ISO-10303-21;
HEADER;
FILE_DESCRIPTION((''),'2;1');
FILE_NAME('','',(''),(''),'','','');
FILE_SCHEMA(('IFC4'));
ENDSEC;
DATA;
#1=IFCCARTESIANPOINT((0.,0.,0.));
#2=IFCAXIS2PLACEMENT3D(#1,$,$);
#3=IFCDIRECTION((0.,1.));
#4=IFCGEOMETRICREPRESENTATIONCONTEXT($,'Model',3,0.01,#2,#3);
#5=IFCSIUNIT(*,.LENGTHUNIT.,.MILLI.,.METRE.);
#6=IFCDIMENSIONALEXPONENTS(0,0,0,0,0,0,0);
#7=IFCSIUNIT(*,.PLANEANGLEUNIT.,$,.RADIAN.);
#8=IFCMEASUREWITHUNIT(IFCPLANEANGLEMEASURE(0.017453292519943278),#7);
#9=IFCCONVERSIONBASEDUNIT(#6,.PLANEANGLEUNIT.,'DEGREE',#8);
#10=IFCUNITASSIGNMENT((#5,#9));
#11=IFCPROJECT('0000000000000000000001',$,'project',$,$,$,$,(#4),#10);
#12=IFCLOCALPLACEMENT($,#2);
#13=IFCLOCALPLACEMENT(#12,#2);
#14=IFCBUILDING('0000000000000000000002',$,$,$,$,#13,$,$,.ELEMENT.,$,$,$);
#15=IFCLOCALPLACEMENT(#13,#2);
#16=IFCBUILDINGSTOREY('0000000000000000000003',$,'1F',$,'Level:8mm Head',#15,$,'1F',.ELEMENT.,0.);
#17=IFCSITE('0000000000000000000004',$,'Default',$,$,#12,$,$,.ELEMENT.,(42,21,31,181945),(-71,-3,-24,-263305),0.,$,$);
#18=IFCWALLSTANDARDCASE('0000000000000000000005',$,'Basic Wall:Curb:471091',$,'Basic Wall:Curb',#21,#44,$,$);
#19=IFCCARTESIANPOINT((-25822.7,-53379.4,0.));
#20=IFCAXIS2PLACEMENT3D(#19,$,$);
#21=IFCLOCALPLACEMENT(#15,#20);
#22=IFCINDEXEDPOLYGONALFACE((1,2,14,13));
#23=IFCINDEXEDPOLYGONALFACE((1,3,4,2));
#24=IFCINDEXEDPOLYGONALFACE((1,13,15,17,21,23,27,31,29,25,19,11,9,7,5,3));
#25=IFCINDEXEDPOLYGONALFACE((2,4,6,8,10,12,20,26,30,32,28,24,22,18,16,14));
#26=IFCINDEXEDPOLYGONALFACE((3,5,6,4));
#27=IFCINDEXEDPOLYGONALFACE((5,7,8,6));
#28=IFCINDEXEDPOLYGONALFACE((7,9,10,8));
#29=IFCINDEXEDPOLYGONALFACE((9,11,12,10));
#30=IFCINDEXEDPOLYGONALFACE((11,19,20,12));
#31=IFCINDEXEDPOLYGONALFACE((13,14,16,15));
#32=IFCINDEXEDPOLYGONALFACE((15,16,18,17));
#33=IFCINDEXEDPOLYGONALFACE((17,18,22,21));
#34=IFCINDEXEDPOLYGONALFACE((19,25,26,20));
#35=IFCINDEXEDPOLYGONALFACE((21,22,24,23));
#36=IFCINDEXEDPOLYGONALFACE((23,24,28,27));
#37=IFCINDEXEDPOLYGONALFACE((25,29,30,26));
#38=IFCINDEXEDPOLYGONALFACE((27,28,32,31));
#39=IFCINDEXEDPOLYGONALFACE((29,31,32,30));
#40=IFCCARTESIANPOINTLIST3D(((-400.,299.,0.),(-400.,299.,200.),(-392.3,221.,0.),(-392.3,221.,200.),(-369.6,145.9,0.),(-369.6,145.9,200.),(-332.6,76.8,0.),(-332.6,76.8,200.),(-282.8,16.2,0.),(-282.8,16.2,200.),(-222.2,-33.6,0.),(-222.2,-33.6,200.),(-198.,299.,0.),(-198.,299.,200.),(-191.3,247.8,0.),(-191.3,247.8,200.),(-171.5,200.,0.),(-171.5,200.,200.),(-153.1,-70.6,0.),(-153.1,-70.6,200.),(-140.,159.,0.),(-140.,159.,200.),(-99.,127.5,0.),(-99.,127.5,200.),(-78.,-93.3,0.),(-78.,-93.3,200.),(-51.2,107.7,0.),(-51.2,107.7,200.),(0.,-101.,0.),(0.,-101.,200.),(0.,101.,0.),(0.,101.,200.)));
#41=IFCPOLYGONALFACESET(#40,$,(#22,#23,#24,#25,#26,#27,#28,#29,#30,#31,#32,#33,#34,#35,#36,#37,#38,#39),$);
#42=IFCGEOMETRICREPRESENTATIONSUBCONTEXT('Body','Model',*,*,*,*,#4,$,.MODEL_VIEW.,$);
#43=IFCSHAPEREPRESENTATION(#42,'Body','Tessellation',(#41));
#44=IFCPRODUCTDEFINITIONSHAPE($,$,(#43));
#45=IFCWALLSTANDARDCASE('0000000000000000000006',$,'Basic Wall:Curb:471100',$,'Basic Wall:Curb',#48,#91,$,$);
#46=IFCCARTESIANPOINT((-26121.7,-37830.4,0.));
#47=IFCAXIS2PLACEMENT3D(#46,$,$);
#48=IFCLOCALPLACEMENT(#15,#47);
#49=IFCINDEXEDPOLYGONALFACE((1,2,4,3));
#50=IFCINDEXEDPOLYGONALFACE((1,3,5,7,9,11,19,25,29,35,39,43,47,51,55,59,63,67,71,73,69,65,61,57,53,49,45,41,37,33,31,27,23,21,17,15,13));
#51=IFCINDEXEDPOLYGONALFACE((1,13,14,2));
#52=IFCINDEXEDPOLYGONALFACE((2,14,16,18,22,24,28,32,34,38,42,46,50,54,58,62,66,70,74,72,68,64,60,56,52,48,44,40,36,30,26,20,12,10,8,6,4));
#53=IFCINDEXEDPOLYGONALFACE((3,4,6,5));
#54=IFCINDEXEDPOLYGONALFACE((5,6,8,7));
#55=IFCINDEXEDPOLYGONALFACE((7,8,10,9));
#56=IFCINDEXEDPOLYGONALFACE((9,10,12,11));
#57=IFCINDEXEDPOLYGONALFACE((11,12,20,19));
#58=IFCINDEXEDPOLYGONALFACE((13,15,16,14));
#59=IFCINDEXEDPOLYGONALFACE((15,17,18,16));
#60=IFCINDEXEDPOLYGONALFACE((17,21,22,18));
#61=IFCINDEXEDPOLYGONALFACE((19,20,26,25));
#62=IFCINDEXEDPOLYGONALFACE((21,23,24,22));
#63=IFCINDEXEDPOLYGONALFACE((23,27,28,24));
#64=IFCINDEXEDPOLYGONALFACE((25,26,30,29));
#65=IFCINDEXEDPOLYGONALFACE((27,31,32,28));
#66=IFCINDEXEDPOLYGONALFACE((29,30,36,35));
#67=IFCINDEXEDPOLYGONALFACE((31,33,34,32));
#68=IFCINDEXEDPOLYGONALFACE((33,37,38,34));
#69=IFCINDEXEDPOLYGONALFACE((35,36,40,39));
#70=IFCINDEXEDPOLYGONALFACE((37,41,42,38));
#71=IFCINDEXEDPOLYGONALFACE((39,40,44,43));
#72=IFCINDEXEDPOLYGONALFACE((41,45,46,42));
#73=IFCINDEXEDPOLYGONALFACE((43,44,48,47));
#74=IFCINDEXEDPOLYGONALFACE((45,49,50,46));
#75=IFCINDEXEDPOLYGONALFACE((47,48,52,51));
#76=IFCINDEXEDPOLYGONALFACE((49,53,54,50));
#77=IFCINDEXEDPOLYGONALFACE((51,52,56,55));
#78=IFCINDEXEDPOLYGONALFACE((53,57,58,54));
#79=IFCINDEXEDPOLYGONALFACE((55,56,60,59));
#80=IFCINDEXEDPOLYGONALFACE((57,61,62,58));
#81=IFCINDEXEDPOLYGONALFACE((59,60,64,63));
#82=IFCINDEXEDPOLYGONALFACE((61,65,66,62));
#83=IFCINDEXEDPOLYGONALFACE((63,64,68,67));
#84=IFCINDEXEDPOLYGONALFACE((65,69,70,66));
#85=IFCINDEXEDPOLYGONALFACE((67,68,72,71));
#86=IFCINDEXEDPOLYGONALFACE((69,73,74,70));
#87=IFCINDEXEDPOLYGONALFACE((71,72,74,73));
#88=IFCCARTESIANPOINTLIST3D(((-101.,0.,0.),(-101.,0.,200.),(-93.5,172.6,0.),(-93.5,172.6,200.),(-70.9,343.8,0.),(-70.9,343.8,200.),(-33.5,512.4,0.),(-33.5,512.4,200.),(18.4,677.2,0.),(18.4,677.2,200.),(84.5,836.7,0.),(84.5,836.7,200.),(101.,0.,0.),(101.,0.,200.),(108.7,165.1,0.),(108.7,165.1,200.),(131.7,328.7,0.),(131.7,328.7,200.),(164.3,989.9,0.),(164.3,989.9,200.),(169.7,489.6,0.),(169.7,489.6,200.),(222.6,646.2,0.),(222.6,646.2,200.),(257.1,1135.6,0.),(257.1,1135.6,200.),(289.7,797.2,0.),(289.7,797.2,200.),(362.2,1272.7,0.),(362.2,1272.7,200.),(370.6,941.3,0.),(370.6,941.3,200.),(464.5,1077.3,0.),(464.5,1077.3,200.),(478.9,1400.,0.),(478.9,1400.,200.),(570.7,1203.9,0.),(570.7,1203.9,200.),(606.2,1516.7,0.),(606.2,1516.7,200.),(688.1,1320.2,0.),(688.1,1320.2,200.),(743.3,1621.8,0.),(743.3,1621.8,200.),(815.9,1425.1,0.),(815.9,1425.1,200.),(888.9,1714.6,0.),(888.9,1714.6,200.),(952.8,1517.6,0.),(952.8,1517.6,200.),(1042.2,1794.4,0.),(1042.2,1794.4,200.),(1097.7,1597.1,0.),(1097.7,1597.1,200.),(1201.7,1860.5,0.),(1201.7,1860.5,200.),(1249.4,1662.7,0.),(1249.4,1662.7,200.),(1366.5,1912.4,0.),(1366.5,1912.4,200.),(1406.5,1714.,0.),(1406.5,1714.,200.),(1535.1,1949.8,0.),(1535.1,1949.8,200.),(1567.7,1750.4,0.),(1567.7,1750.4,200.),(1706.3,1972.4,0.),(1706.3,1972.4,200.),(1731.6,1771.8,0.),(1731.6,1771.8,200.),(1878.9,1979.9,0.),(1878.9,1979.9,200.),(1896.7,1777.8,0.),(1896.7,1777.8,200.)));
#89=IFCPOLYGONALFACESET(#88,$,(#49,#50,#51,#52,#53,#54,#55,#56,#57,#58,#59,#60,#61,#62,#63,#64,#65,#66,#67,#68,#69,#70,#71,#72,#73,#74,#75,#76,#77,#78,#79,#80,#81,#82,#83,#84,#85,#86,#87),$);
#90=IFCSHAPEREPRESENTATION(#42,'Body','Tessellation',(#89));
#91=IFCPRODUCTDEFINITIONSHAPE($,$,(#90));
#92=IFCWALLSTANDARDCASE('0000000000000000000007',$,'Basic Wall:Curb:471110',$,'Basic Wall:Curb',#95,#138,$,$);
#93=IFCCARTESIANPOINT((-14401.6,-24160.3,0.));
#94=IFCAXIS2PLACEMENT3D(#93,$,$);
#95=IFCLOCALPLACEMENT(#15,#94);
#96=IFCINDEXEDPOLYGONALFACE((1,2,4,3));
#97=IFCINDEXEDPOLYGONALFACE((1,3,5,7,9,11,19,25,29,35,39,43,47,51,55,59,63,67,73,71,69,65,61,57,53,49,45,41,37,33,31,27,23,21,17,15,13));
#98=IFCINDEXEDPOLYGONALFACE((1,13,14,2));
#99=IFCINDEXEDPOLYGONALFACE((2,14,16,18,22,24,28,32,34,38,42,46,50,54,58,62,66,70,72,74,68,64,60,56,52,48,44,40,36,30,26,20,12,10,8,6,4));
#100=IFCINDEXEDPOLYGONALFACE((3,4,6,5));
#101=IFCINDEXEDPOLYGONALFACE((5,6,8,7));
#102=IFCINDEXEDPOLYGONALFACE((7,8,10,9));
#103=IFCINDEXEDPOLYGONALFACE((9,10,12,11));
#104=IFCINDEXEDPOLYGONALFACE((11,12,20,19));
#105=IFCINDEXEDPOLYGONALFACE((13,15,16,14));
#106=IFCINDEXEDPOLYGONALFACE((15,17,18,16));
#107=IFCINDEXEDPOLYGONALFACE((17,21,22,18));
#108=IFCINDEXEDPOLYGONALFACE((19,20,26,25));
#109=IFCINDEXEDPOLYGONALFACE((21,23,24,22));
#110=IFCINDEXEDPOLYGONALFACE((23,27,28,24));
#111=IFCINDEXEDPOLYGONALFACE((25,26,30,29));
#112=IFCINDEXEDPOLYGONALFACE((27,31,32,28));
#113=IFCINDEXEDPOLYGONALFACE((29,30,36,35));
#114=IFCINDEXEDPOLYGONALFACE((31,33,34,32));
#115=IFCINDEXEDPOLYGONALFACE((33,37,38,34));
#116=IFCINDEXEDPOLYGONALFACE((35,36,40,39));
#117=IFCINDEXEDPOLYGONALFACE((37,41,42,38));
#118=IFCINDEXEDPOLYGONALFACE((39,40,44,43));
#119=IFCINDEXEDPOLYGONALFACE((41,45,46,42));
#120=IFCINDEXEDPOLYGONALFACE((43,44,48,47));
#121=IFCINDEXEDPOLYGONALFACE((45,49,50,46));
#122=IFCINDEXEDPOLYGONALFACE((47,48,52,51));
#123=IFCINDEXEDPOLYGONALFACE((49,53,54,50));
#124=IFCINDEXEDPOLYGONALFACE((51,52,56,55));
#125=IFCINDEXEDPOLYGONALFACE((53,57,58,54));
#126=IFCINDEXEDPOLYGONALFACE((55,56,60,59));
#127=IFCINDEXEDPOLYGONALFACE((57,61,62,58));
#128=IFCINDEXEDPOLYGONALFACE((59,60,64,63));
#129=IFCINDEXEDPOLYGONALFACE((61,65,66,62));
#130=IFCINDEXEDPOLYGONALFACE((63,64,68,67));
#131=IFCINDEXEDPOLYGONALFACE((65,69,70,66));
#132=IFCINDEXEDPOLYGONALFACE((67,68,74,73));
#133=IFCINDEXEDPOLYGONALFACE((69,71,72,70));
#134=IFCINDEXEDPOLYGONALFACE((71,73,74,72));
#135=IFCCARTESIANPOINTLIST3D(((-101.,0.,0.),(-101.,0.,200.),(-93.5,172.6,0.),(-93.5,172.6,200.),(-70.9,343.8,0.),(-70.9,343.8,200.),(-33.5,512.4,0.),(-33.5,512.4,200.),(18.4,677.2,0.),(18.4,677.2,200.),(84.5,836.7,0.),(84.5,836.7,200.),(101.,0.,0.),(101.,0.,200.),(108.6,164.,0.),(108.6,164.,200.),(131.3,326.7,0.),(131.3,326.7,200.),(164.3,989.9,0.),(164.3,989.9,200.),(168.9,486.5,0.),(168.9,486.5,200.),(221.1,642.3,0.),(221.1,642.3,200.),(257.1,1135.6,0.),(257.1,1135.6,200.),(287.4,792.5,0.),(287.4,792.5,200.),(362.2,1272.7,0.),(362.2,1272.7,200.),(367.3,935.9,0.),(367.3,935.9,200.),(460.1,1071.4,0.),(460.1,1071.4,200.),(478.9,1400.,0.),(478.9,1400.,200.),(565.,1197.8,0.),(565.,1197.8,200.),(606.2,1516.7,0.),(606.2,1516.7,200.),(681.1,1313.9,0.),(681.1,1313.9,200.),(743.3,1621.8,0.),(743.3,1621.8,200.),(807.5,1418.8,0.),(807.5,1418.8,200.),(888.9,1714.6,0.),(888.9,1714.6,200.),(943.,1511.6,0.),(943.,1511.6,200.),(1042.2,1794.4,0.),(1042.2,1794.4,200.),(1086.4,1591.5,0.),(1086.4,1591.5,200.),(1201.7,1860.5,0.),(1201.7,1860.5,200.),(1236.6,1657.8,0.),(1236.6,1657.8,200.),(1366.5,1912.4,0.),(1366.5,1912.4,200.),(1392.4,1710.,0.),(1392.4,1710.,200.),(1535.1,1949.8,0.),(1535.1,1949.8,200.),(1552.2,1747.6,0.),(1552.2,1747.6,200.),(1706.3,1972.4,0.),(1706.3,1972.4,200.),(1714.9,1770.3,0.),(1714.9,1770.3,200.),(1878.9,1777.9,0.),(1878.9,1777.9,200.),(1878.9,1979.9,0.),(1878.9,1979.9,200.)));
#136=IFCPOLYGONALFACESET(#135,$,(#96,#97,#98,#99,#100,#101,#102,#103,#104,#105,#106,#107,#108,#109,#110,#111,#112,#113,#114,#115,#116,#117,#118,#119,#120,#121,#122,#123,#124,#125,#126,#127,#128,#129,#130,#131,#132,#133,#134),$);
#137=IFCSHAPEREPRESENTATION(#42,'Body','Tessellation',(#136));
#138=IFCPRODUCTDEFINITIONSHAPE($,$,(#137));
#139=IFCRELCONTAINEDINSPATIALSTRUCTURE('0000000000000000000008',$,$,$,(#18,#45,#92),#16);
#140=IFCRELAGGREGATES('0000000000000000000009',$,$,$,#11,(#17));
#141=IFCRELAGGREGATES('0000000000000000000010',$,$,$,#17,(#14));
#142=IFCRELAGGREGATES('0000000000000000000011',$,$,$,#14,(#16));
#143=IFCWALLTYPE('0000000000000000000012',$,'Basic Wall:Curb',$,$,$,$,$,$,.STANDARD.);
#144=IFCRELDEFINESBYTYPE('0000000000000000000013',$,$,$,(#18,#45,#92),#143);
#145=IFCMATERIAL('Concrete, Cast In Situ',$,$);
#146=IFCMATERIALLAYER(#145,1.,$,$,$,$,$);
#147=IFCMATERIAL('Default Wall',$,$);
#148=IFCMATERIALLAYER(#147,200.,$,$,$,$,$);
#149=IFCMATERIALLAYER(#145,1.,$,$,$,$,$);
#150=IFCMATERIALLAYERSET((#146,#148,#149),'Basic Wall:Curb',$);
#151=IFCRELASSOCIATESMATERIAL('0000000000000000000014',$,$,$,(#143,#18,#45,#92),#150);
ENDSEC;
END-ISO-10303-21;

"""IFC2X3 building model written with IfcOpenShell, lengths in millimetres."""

from ifc_helpers import new_model, entity, si_unit, converted_unit, direction, frame, frame_2d, origin, place, context, subcontext, project, spatial, polyline, circle_curve, parameter, trimmed, segment, composite_curve, outline, extrude, material, layer, layer_set, layer_usage, type_object, element, save


model = new_model("IFC2X3")

# Units and contexts
model_context = context("Model", 3, precision=0.01, world=origin(), true_north=direction((0.0, 1.0)))
body_context = subcontext(model_context, "Body", "Model", "MODEL_VIEW")
ifc_project = project(units=[si_unit("LENGTHUNIT", "METRE", prefix="MILLI"), converted_unit("PLANEANGLEUNIT", "DEGREE", entity("IfcPlaneAngleMeasure", 0.017453292519943278), si_unit("PLANEANGLEUNIT", "RADIAN"), dimensions=[0, 0, 0, 0, 0, 0, 0])], contexts=[model_context])

# Site, building, storey
site_placement = place(None, origin())
site = spatial("IfcSite", under=ifc_project, at=site_placement, Name="Default", CompositionType="ELEMENT", RefLatitude=(42, 21, 31, 181945), RefLongitude=(-71, -3, -24, -263305), RefElevation=0.0)
building_placement = place(site_placement, origin())
building = spatial("IfcBuilding", under=site, at=building_placement, CompositionType="ELEMENT")
storey_placement = place(building_placement, origin())
storey = spatial("IfcBuildingStorey", under=building, at=storey_placement, Name="1F", ObjectType="Level:8mm Head", LongName="1F", CompositionType="ELEMENT", Elevation=0.0)

# Shared definitions
ifc_material_1 = material(Name="Default Wall")

# Walls
ifc_material_2 = material(Name="Concrete, Cast In Situ")
ifc_layer_1 = layer(ifc_material_2, 1.0)
ifc_layer_2 = layer(ifc_material_1, 200.0)
ifc_layer_3 = layer(ifc_material_2, 1.0)
ifc_layer_set_1 = layer_set([ifc_layer_1, ifc_layer_2, ifc_layer_3], Name="Basic Wall:Curb")
ifc_layer_usage_1 = layer_usage(ifc_layer_set_1, "AXIS2", "POSITIVE", -101.0)
wall_type_1 = type_object("IfcWallType", Name="Basic Wall:Curb", PredefinedType="STANDARD", material=ifc_layer_set_1)
wall_1_placement = place(storey_placement, frame((-25822.7, -53379.4, 0.0)))
element("IfcWallStandardCase", 1, at=wall_1_placement, inside=storey, type_object=wall_type_1, material=ifc_layer_usage_1, Name="Basic Wall:Curb:471091", ObjectType="Basic Wall:Curb", context=body_context, shape_type="SweptSolid", body=[
    extrude(outline(composite_curve([segment(trimmed(circle_curve(frame_2d((0.0, 299.0), x_axis=(1.0, 0.0)), 400.0), [parameter(180.0)], [parameter(270.0)], True, "PARAMETER"), True, "CONTINUOUS"), segment(polyline([(0.0, -101.0), (0.0, 101.0)]), True, "CONTINUOUS"), segment(trimmed(circle_curve(frame_2d((0.0, 299.0), x_axis=(1.0, 0.0)), 198.0), [parameter(180.0)], [parameter(270.0)], True, "PARAMETER"), False, "CONTINUOUS"), segment(polyline([(-198.0, 299.0), (-400.0, 299.0)]), True, "CONTINUOUS")], self_intersect=False)), origin(), (0.0, 0.0, 1.0), 200.0),
])
ifc_layer_usage_2 = layer_usage(ifc_layer_set_1, "AXIS2", "POSITIVE", -101.0)
wall_2_placement = place(storey_placement, frame((-26121.7, -37830.4, 0.0)))
element("IfcWallStandardCase", 2, at=wall_2_placement, inside=storey, type_object=wall_type_1, material=ifc_layer_usage_2, Name="Basic Wall:Curb:471100", ObjectType="Basic Wall:Curb", context=body_context, shape_type="SweptSolid", body=[
    extrude(outline(composite_curve([segment(trimmed(circle_curve(frame_2d((1878.9, 0.0), x_axis=(1.0, 0.0)), 1979.9), [parameter(90.0)], [parameter(180.0)], True, "PARAMETER"), True, "CONTINUOUS"), segment(polyline([(-101.0, 0.0), (101.0, 0.0)]), True, "CONTINUOUS"), segment(trimmed(circle_curve(frame_2d((1878.9, 0.0), x_axis=(1.0, 0.0)), 1777.9), [parameter(89.425974)], [parameter(180.0)], True, "PARAMETER"), False, "CONTINUOUS"), segment(polyline([(1896.7, 1777.8), (1878.9, 1979.9)]), True, "CONTINUOUS")], self_intersect=False)), origin(), (0.0, 0.0, 1.0), 200.0),
])
ifc_layer_usage_3 = layer_usage(ifc_layer_set_1, "AXIS2", "POSITIVE", -101.0)
wall_3_placement = place(storey_placement, frame((-14401.6, -24160.3, 0.0)))
element("IfcWallStandardCase", 3, at=wall_3_placement, inside=storey, type_object=wall_type_1, material=ifc_layer_usage_3, Name="Basic Wall:Curb:471110", ObjectType="Basic Wall:Curb", context=body_context, shape_type="SweptSolid", body=[
    extrude(outline(composite_curve([segment(trimmed(circle_curve(frame_2d((1878.9, 0.0), x_axis=(1.0, 0.0)), 1979.9), [parameter(90.0)], [parameter(180.0)], True, "PARAMETER"), True, "CONTINUOUS"), segment(polyline([(-101.0, 0.0), (101.0, 0.0)]), True, "CONTINUOUS"), segment(trimmed(circle_curve(frame_2d((1878.9, 0.0), x_axis=(1.0, 0.0)), 1777.9), [parameter(90.0)], [parameter(180.0)], True, "PARAMETER"), False, "CONTINUOUS"), segment(polyline([(1878.9, 1777.9), (1878.9, 1979.9)]), True, "CONTINUOUS")], self_intersect=False)), origin(), (0.0, 0.0, 1.0), 200.0),
])

save(model, "model.ifc")
